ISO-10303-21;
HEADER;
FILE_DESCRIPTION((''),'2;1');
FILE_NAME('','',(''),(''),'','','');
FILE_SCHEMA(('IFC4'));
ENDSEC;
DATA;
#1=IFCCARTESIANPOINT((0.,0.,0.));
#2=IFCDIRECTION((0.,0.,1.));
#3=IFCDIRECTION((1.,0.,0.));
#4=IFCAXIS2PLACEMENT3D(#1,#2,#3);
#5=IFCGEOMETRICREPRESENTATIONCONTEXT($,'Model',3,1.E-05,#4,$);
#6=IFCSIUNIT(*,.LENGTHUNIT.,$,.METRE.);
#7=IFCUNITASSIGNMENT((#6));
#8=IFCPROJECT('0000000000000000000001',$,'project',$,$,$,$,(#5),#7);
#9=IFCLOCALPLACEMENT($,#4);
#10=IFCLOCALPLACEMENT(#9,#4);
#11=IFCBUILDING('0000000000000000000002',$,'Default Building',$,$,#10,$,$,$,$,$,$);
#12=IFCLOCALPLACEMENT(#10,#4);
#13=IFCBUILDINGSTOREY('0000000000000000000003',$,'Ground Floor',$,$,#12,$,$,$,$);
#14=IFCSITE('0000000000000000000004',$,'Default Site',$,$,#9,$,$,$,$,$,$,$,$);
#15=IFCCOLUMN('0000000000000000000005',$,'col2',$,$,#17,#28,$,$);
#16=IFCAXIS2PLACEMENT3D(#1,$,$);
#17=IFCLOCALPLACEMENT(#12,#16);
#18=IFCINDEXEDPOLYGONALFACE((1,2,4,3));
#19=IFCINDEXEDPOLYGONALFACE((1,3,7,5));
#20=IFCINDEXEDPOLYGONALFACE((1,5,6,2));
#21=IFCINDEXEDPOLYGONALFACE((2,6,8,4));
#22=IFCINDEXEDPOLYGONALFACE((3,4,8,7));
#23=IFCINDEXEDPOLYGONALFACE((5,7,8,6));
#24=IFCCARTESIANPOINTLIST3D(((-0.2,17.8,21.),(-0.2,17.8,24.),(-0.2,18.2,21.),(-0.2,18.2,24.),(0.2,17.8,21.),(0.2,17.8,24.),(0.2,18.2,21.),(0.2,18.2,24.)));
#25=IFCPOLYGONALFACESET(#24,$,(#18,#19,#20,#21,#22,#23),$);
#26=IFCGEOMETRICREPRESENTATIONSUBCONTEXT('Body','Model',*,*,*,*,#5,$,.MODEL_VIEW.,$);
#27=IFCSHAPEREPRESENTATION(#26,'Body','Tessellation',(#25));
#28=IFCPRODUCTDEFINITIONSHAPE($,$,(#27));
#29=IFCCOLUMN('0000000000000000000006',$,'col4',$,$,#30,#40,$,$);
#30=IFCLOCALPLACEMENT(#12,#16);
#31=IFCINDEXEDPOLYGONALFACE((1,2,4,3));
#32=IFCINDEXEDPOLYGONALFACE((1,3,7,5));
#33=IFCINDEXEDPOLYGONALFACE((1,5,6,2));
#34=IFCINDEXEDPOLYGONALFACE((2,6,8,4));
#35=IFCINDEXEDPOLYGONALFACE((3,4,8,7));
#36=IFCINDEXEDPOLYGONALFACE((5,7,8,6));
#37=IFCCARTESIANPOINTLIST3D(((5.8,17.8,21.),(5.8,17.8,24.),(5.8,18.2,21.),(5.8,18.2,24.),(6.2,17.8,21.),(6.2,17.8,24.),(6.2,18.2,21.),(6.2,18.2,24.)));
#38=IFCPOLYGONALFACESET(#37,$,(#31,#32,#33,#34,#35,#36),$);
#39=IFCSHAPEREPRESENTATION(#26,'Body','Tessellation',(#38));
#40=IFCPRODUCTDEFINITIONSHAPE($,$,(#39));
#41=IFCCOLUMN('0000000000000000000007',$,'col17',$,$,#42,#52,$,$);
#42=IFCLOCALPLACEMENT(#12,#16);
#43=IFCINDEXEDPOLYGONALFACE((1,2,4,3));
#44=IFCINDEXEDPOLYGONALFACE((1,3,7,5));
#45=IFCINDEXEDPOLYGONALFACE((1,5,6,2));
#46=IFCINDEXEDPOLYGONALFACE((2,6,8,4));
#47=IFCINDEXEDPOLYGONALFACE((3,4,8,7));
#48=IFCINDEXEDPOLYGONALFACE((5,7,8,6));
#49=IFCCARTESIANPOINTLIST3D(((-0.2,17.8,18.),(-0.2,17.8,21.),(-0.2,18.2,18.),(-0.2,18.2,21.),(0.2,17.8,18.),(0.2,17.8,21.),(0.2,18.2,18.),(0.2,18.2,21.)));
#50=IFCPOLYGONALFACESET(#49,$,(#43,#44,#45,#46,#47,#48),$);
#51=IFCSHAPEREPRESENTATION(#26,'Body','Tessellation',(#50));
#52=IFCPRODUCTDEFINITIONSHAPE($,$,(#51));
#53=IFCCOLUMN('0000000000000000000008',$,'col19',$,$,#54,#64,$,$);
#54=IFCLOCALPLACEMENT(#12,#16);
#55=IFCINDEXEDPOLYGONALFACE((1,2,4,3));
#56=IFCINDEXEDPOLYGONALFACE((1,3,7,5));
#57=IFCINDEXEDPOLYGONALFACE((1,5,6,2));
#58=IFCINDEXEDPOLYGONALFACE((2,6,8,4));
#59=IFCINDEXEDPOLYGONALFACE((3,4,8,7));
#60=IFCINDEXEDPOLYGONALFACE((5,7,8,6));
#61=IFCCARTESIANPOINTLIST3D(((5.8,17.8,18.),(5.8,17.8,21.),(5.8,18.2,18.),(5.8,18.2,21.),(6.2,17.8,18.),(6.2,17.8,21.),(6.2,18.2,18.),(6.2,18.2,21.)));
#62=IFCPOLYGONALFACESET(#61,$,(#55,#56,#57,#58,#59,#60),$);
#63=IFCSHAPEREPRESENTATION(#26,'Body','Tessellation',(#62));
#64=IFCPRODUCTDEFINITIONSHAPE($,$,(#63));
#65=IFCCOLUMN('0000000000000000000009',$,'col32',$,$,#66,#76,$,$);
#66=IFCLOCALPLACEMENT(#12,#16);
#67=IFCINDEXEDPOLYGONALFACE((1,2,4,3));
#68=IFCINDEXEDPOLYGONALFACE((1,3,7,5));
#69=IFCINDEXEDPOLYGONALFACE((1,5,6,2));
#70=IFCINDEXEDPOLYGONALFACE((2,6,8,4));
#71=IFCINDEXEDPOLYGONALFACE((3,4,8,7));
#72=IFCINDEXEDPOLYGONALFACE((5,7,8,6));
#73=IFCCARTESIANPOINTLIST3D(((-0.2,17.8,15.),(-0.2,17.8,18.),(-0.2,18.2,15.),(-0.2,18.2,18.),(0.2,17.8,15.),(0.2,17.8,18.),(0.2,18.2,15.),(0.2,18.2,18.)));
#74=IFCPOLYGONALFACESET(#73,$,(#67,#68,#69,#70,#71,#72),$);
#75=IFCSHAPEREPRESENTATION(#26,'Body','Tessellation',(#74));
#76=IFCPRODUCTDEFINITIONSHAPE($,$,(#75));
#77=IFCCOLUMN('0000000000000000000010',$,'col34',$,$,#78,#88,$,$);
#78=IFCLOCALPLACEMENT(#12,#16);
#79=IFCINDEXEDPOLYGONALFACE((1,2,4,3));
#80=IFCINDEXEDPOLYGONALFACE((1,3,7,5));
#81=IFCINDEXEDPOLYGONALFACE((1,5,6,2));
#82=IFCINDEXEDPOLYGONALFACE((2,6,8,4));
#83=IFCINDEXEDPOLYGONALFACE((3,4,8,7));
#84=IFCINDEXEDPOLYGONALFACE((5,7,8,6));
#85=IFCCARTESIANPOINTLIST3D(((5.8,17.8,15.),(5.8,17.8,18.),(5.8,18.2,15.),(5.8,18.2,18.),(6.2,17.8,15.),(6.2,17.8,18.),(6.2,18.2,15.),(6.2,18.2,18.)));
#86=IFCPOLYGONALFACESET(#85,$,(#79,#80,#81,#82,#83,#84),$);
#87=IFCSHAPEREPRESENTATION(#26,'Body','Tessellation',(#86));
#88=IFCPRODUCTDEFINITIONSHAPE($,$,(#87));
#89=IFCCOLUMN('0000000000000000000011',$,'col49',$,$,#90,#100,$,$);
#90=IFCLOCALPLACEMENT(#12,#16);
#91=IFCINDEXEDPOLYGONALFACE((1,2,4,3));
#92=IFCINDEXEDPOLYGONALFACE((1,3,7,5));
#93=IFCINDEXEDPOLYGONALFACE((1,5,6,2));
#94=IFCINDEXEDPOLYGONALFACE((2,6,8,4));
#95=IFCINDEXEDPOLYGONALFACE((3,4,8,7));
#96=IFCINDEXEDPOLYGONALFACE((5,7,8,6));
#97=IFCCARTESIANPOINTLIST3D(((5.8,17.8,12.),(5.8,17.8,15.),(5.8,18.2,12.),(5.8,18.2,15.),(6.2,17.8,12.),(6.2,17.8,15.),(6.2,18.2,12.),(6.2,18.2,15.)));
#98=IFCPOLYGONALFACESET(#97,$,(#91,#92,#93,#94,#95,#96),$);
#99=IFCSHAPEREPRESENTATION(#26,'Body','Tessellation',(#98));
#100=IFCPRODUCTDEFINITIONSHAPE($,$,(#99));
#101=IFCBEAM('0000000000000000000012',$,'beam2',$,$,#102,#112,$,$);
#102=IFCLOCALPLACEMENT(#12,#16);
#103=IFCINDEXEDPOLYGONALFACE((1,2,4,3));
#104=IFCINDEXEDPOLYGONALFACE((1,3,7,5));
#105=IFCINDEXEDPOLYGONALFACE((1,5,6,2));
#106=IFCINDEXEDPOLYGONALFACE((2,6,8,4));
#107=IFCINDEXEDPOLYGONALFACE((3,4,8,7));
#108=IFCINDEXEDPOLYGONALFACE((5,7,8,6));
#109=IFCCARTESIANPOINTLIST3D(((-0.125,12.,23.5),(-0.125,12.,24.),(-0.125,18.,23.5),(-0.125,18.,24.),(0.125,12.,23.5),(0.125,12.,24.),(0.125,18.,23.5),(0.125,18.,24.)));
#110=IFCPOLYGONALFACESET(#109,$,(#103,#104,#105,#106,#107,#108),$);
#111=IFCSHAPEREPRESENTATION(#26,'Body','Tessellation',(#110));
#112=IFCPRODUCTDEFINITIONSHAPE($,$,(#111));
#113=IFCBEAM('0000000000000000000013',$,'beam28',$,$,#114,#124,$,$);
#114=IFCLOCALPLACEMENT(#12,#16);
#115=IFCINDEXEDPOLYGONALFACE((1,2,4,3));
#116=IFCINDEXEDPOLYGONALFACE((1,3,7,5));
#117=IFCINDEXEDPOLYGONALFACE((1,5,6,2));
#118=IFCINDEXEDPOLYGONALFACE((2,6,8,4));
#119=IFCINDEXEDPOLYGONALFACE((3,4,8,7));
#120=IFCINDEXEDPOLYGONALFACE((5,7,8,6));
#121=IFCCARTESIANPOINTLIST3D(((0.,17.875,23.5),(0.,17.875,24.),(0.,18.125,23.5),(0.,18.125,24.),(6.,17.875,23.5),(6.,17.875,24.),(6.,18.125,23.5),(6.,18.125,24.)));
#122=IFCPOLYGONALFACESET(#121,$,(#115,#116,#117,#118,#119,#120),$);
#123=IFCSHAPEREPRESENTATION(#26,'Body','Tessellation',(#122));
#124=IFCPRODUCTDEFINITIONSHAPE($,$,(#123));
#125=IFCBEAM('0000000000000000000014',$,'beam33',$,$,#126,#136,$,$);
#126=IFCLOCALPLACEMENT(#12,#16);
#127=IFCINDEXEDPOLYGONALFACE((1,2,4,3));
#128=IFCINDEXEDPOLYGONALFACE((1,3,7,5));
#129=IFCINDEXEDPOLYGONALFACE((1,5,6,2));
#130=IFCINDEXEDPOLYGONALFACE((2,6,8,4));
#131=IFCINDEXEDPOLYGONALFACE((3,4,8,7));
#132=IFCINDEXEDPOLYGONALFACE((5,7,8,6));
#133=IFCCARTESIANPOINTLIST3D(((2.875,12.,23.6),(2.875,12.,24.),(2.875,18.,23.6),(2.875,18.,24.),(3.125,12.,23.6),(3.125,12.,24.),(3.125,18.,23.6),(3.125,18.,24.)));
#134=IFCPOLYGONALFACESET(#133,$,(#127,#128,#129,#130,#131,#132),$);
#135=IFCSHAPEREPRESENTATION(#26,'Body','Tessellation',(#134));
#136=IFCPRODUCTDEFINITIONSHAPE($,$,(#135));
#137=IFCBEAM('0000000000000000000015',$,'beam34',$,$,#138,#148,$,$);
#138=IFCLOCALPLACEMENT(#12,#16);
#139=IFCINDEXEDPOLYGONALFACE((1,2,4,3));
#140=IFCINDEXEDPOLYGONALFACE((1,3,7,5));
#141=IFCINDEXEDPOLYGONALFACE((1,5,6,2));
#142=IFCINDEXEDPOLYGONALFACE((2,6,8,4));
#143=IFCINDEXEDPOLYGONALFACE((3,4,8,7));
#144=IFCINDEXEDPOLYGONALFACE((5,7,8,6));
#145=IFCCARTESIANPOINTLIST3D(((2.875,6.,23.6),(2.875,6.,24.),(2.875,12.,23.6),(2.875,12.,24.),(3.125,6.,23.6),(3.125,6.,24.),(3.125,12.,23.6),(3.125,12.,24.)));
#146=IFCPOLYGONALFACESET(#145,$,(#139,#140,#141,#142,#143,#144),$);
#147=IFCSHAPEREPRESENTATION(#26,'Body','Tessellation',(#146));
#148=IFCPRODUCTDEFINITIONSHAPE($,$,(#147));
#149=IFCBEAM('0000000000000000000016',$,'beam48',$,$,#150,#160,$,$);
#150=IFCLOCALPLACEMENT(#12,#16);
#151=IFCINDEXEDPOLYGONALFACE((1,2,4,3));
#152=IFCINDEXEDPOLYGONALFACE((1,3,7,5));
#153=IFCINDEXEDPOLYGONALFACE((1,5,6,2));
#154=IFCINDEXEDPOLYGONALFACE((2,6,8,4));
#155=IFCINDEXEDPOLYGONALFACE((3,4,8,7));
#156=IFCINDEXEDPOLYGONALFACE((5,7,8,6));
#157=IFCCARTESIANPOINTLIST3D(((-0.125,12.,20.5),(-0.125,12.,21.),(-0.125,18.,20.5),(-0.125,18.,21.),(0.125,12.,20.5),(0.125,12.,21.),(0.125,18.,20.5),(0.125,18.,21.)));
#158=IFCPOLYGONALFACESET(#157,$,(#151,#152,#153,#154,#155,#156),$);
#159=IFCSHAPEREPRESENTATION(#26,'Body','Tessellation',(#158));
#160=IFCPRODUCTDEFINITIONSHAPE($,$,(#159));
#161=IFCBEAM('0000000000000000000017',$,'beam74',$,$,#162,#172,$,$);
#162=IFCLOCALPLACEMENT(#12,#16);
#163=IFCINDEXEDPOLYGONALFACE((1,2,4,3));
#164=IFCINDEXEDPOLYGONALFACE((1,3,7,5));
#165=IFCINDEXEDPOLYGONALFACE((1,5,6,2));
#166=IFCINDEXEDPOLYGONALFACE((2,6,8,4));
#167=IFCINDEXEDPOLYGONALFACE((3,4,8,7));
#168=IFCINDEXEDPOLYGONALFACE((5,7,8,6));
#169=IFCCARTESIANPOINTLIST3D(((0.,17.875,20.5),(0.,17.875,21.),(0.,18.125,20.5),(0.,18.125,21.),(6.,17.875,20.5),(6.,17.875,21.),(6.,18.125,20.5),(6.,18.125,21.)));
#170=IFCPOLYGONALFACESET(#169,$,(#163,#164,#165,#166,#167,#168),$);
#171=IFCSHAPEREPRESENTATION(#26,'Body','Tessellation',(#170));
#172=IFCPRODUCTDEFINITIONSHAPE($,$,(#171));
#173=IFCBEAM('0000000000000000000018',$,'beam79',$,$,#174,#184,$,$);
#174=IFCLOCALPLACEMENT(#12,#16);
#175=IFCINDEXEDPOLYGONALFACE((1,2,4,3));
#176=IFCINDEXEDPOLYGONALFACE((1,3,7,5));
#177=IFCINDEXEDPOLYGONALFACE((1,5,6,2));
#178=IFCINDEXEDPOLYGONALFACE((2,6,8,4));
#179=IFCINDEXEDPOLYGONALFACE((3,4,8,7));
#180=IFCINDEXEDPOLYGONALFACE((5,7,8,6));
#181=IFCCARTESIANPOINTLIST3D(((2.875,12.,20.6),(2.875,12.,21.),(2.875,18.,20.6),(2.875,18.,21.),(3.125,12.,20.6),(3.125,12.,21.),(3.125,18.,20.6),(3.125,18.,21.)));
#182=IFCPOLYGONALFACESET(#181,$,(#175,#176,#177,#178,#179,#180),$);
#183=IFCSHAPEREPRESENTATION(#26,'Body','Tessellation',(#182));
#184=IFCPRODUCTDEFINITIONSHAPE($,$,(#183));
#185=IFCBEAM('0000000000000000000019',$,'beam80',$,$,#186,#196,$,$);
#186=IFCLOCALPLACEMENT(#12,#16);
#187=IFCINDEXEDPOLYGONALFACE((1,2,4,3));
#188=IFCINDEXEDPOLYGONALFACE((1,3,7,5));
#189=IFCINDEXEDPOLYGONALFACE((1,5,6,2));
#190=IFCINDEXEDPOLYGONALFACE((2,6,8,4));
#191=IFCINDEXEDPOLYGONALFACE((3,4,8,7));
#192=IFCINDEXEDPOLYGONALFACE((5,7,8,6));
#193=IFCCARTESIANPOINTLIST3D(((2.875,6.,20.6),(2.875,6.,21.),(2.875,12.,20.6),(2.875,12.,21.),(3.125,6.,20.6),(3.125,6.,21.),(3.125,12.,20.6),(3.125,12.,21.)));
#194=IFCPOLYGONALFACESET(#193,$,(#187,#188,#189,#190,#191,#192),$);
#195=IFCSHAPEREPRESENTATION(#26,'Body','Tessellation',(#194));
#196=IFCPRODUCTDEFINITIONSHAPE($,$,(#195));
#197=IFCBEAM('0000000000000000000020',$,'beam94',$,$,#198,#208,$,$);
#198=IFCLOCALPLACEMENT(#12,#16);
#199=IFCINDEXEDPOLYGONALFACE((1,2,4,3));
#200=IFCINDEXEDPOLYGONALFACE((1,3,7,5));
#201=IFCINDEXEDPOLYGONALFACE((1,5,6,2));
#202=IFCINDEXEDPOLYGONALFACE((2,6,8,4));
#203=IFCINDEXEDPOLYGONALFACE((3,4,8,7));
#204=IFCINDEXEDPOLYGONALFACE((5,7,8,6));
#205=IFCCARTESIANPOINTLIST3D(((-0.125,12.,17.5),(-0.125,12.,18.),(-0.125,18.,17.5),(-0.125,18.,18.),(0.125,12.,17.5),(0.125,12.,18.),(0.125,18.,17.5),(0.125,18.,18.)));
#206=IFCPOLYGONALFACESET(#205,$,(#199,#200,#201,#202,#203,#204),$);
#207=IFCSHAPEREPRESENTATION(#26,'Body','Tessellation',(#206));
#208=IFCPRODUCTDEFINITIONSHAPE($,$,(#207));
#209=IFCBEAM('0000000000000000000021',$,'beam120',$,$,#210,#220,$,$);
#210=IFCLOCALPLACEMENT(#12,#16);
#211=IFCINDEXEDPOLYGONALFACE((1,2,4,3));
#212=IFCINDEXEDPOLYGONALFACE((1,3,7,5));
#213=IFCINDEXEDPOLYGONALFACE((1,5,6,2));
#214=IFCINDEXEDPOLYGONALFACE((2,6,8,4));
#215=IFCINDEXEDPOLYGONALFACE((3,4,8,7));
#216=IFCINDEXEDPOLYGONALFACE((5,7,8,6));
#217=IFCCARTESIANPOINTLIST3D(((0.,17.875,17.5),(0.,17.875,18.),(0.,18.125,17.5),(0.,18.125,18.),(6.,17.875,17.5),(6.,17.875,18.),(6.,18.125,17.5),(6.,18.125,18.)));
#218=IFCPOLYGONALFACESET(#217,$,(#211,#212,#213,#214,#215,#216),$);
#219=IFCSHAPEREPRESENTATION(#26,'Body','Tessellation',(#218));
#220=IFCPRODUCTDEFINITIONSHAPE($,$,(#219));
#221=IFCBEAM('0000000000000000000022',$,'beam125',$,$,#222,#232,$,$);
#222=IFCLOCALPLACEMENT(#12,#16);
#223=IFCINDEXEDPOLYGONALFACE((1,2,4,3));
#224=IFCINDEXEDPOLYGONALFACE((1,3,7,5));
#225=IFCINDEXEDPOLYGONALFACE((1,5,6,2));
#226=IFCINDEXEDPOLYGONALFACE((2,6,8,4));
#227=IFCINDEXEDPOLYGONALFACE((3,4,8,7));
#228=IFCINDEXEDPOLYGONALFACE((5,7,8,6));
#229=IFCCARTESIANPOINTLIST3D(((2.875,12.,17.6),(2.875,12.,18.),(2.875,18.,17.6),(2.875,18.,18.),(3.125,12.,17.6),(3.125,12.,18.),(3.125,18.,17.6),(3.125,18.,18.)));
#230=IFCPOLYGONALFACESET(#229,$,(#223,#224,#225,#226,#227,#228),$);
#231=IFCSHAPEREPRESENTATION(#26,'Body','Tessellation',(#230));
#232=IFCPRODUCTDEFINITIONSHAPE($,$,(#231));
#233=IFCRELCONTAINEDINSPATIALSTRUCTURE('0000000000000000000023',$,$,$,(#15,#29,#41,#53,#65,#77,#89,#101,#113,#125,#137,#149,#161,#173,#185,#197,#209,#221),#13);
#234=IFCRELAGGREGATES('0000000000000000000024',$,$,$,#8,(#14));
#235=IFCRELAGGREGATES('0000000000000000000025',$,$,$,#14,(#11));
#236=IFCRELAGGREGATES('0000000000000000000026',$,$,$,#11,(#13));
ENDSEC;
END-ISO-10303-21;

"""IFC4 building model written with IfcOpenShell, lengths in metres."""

from ifc_helpers import new_model, si_unit, frame, origin_with_axes, place, context, subcontext, project, spatial, indexed_curve, outline, extrude, element, save


model = new_model("IFC4")

# Units and contexts
model_context = context("Model", 3, precision=1e-05, world=origin_with_axes())
body_context = subcontext(model_context, "Body", "Model", "MODEL_VIEW")
ifc_project = project(units=[si_unit("LENGTHUNIT", "METRE")], contexts=[model_context])

# Site, building, storey
site_placement = place(None, origin_with_axes())
site = spatial("IfcSite", under=ifc_project, at=site_placement, Name="Default Site")
building_placement = place(site_placement, origin_with_axes())
building = spatial("IfcBuilding", under=site, at=building_placement, Name="Default Building")
storey_placement = place(building_placement, origin_with_axes())
storey = spatial("IfcBuildingStorey", under=building, at=storey_placement, Name="Ground Floor")

# Columns
for number, where, z_axis, x_axis, name in (
    (1, (-0.2, 17.8, 21.0), (0.0, 0.0, 1.0), (1.0, 0.0, 0.0), "col2"),
    (2, (5.8, 17.8, 21.0), (0.0, 0.0, 1.0), (1.0, 0.0, 0.0), "col4"),
    (3, (-0.2, 17.8, 18.0), (0.0, 0.0, 1.0), (1.0, 0.0, 0.0), "col17"),
    (4, (5.8, 17.8, 18.0), (0.0, 0.0, 1.0), (1.0, 0.0, 0.0), "col19"),
    (5, (-0.2, 17.8, 15.0), (0.0, 0.0, 1.0), (1.0, 0.0, 0.0), "col32"),
    (6, (5.8, 17.8, 15.0), (0.0, 0.0, 1.0), (1.0, 0.0, 0.0), "col34"),
    (7, (5.8, 17.8, 12.0), (0.0, 0.0, 1.0), (1.0, 0.0, 0.0), "col49"),
):
    element("IfcColumn", number, at=place(storey_placement, frame(where, z_axis=z_axis, x_axis=x_axis)), inside=storey, Name=name, context=body_context, shape_type="SweptSolid", body=[
        extrude(outline(indexed_curve([(0.0, 0.0), (0.0, 0.4), (0.4, 0.4), (0.4, 0.0), (0.0, 0.0)], self_intersect=False)), origin_with_axes(), (0.0, 0.0, 1.0), 3.0),
    ])

# Beams
for number, where, z_axis, x_axis, name in (
    (8, (0.125, 12.0, 23.5), (0.0, 0.0, 1.0), (0.0, 1.0, 0.0), "beam2"),
    (9, (0.0, 17.875, 23.5), (0.0, 0.0, 1.0), (1.0, 0.0, 0.0), "beam28"),
):
    element("IfcBeam", number, at=place(storey_placement, frame(where, z_axis=z_axis, x_axis=x_axis)), inside=storey, Name=name, context=body_context, shape_type="SweptSolid", body=[
        extrude(outline(indexed_curve([(0.0, 0.0), (0.0, 0.25), (6.0, 0.25), (6.0, 0.0), (0.0, 0.0)], self_intersect=False)), origin_with_axes(), (0.0, 0.0, 1.0), 0.5),
    ])
for number, where, z_axis, x_axis, name in (
    (10, (2.875, 18.0, 23.6), (0.0, 0.0, 1.0), (0.0, -1.0, 0.0), "beam33"),
    (11, (2.875, 12.0, 23.6), (0.0, 0.0, 1.0), (0.0, -1.0, 0.0), "beam34"),
):
    element("IfcBeam", number, at=place(storey_placement, frame(where, z_axis=z_axis, x_axis=x_axis)), inside=storey, Name=name, context=body_context, shape_type="SweptSolid", body=[
        extrude(outline(indexed_curve([(0.0, 0.0), (0.0, 0.25), (6.0, 0.25), (6.0, 0.0), (0.0, 0.0)], self_intersect=False)), origin_with_axes(), (0.0, 0.0, 1.0), 0.4),
    ])
for number, where, z_axis, x_axis, name in (
    (12, (0.125, 12.0, 20.5), (0.0, 0.0, 1.0), (0.0, 1.0, 0.0), "beam48"),
    (13, (0.0, 17.875, 20.5), (0.0, 0.0, 1.0), (1.0, 0.0, 0.0), "beam74"),
):
    element("IfcBeam", number, at=place(storey_placement, frame(where, z_axis=z_axis, x_axis=x_axis)), inside=storey, Name=name, context=body_context, shape_type="SweptSolid", body=[
        extrude(outline(indexed_curve([(0.0, 0.0), (0.0, 0.25), (6.0, 0.25), (6.0, 0.0), (0.0, 0.0)], self_intersect=False)), origin_with_axes(), (0.0, 0.0, 1.0), 0.5),
    ])
for number, where, z_axis, x_axis, name in (
    (14, (2.875, 18.0, 20.6), (0.0, 0.0, 1.0), (0.0, -1.0, 0.0), "beam79"),
    (15, (2.875, 12.0, 20.6), (0.0, 0.0, 1.0), (0.0, -1.0, 0.0), "beam80"),
):
    element("IfcBeam", number, at=place(storey_placement, frame(where, z_axis=z_axis, x_axis=x_axis)), inside=storey, Name=name, context=body_context, shape_type="SweptSolid", body=[
        extrude(outline(indexed_curve([(0.0, 0.0), (0.0, 0.25), (6.0, 0.25), (6.0, 0.0), (0.0, 0.0)], self_intersect=False)), origin_with_axes(), (0.0, 0.0, 1.0), 0.4),
    ])
for number, where, z_axis, x_axis, name in (
    (16, (0.125, 12.0, 17.5), (0.0, 0.0, 1.0), (0.0, 1.0, 0.0), "beam94"),
    (17, (0.0, 17.875, 17.5), (0.0, 0.0, 1.0), (1.0, 0.0, 0.0), "beam120"),
):
    element("IfcBeam", number, at=place(storey_placement, frame(where, z_axis=z_axis, x_axis=x_axis)), inside=storey, Name=name, context=body_context, shape_type="SweptSolid", body=[
        extrude(outline(indexed_curve([(0.0, 0.0), (0.0, 0.25), (6.0, 0.25), (6.0, 0.0), (0.0, 0.0)], self_intersect=False)), origin_with_axes(), (0.0, 0.0, 1.0), 0.5),
    ])
for number, where, z_axis, x_axis, name in (
    (18, (2.875, 18.0, 17.6), (0.0, 0.0, 1.0), (0.0, -1.0, 0.0), "beam125"),
):
    element("IfcBeam", number, at=place(storey_placement, frame(where, z_axis=z_axis, x_axis=x_axis)), inside=storey, Name=name, context=body_context, shape_type="SweptSolid", body=[
        extrude(outline(indexed_curve([(0.0, 0.0), (0.0, 0.25), (6.0, 0.25), (6.0, 0.0), (0.0, 0.0)], self_intersect=False)), origin_with_axes(), (0.0, 0.0, 1.0), 0.4),
    ])

save(model, "model.ifc")
